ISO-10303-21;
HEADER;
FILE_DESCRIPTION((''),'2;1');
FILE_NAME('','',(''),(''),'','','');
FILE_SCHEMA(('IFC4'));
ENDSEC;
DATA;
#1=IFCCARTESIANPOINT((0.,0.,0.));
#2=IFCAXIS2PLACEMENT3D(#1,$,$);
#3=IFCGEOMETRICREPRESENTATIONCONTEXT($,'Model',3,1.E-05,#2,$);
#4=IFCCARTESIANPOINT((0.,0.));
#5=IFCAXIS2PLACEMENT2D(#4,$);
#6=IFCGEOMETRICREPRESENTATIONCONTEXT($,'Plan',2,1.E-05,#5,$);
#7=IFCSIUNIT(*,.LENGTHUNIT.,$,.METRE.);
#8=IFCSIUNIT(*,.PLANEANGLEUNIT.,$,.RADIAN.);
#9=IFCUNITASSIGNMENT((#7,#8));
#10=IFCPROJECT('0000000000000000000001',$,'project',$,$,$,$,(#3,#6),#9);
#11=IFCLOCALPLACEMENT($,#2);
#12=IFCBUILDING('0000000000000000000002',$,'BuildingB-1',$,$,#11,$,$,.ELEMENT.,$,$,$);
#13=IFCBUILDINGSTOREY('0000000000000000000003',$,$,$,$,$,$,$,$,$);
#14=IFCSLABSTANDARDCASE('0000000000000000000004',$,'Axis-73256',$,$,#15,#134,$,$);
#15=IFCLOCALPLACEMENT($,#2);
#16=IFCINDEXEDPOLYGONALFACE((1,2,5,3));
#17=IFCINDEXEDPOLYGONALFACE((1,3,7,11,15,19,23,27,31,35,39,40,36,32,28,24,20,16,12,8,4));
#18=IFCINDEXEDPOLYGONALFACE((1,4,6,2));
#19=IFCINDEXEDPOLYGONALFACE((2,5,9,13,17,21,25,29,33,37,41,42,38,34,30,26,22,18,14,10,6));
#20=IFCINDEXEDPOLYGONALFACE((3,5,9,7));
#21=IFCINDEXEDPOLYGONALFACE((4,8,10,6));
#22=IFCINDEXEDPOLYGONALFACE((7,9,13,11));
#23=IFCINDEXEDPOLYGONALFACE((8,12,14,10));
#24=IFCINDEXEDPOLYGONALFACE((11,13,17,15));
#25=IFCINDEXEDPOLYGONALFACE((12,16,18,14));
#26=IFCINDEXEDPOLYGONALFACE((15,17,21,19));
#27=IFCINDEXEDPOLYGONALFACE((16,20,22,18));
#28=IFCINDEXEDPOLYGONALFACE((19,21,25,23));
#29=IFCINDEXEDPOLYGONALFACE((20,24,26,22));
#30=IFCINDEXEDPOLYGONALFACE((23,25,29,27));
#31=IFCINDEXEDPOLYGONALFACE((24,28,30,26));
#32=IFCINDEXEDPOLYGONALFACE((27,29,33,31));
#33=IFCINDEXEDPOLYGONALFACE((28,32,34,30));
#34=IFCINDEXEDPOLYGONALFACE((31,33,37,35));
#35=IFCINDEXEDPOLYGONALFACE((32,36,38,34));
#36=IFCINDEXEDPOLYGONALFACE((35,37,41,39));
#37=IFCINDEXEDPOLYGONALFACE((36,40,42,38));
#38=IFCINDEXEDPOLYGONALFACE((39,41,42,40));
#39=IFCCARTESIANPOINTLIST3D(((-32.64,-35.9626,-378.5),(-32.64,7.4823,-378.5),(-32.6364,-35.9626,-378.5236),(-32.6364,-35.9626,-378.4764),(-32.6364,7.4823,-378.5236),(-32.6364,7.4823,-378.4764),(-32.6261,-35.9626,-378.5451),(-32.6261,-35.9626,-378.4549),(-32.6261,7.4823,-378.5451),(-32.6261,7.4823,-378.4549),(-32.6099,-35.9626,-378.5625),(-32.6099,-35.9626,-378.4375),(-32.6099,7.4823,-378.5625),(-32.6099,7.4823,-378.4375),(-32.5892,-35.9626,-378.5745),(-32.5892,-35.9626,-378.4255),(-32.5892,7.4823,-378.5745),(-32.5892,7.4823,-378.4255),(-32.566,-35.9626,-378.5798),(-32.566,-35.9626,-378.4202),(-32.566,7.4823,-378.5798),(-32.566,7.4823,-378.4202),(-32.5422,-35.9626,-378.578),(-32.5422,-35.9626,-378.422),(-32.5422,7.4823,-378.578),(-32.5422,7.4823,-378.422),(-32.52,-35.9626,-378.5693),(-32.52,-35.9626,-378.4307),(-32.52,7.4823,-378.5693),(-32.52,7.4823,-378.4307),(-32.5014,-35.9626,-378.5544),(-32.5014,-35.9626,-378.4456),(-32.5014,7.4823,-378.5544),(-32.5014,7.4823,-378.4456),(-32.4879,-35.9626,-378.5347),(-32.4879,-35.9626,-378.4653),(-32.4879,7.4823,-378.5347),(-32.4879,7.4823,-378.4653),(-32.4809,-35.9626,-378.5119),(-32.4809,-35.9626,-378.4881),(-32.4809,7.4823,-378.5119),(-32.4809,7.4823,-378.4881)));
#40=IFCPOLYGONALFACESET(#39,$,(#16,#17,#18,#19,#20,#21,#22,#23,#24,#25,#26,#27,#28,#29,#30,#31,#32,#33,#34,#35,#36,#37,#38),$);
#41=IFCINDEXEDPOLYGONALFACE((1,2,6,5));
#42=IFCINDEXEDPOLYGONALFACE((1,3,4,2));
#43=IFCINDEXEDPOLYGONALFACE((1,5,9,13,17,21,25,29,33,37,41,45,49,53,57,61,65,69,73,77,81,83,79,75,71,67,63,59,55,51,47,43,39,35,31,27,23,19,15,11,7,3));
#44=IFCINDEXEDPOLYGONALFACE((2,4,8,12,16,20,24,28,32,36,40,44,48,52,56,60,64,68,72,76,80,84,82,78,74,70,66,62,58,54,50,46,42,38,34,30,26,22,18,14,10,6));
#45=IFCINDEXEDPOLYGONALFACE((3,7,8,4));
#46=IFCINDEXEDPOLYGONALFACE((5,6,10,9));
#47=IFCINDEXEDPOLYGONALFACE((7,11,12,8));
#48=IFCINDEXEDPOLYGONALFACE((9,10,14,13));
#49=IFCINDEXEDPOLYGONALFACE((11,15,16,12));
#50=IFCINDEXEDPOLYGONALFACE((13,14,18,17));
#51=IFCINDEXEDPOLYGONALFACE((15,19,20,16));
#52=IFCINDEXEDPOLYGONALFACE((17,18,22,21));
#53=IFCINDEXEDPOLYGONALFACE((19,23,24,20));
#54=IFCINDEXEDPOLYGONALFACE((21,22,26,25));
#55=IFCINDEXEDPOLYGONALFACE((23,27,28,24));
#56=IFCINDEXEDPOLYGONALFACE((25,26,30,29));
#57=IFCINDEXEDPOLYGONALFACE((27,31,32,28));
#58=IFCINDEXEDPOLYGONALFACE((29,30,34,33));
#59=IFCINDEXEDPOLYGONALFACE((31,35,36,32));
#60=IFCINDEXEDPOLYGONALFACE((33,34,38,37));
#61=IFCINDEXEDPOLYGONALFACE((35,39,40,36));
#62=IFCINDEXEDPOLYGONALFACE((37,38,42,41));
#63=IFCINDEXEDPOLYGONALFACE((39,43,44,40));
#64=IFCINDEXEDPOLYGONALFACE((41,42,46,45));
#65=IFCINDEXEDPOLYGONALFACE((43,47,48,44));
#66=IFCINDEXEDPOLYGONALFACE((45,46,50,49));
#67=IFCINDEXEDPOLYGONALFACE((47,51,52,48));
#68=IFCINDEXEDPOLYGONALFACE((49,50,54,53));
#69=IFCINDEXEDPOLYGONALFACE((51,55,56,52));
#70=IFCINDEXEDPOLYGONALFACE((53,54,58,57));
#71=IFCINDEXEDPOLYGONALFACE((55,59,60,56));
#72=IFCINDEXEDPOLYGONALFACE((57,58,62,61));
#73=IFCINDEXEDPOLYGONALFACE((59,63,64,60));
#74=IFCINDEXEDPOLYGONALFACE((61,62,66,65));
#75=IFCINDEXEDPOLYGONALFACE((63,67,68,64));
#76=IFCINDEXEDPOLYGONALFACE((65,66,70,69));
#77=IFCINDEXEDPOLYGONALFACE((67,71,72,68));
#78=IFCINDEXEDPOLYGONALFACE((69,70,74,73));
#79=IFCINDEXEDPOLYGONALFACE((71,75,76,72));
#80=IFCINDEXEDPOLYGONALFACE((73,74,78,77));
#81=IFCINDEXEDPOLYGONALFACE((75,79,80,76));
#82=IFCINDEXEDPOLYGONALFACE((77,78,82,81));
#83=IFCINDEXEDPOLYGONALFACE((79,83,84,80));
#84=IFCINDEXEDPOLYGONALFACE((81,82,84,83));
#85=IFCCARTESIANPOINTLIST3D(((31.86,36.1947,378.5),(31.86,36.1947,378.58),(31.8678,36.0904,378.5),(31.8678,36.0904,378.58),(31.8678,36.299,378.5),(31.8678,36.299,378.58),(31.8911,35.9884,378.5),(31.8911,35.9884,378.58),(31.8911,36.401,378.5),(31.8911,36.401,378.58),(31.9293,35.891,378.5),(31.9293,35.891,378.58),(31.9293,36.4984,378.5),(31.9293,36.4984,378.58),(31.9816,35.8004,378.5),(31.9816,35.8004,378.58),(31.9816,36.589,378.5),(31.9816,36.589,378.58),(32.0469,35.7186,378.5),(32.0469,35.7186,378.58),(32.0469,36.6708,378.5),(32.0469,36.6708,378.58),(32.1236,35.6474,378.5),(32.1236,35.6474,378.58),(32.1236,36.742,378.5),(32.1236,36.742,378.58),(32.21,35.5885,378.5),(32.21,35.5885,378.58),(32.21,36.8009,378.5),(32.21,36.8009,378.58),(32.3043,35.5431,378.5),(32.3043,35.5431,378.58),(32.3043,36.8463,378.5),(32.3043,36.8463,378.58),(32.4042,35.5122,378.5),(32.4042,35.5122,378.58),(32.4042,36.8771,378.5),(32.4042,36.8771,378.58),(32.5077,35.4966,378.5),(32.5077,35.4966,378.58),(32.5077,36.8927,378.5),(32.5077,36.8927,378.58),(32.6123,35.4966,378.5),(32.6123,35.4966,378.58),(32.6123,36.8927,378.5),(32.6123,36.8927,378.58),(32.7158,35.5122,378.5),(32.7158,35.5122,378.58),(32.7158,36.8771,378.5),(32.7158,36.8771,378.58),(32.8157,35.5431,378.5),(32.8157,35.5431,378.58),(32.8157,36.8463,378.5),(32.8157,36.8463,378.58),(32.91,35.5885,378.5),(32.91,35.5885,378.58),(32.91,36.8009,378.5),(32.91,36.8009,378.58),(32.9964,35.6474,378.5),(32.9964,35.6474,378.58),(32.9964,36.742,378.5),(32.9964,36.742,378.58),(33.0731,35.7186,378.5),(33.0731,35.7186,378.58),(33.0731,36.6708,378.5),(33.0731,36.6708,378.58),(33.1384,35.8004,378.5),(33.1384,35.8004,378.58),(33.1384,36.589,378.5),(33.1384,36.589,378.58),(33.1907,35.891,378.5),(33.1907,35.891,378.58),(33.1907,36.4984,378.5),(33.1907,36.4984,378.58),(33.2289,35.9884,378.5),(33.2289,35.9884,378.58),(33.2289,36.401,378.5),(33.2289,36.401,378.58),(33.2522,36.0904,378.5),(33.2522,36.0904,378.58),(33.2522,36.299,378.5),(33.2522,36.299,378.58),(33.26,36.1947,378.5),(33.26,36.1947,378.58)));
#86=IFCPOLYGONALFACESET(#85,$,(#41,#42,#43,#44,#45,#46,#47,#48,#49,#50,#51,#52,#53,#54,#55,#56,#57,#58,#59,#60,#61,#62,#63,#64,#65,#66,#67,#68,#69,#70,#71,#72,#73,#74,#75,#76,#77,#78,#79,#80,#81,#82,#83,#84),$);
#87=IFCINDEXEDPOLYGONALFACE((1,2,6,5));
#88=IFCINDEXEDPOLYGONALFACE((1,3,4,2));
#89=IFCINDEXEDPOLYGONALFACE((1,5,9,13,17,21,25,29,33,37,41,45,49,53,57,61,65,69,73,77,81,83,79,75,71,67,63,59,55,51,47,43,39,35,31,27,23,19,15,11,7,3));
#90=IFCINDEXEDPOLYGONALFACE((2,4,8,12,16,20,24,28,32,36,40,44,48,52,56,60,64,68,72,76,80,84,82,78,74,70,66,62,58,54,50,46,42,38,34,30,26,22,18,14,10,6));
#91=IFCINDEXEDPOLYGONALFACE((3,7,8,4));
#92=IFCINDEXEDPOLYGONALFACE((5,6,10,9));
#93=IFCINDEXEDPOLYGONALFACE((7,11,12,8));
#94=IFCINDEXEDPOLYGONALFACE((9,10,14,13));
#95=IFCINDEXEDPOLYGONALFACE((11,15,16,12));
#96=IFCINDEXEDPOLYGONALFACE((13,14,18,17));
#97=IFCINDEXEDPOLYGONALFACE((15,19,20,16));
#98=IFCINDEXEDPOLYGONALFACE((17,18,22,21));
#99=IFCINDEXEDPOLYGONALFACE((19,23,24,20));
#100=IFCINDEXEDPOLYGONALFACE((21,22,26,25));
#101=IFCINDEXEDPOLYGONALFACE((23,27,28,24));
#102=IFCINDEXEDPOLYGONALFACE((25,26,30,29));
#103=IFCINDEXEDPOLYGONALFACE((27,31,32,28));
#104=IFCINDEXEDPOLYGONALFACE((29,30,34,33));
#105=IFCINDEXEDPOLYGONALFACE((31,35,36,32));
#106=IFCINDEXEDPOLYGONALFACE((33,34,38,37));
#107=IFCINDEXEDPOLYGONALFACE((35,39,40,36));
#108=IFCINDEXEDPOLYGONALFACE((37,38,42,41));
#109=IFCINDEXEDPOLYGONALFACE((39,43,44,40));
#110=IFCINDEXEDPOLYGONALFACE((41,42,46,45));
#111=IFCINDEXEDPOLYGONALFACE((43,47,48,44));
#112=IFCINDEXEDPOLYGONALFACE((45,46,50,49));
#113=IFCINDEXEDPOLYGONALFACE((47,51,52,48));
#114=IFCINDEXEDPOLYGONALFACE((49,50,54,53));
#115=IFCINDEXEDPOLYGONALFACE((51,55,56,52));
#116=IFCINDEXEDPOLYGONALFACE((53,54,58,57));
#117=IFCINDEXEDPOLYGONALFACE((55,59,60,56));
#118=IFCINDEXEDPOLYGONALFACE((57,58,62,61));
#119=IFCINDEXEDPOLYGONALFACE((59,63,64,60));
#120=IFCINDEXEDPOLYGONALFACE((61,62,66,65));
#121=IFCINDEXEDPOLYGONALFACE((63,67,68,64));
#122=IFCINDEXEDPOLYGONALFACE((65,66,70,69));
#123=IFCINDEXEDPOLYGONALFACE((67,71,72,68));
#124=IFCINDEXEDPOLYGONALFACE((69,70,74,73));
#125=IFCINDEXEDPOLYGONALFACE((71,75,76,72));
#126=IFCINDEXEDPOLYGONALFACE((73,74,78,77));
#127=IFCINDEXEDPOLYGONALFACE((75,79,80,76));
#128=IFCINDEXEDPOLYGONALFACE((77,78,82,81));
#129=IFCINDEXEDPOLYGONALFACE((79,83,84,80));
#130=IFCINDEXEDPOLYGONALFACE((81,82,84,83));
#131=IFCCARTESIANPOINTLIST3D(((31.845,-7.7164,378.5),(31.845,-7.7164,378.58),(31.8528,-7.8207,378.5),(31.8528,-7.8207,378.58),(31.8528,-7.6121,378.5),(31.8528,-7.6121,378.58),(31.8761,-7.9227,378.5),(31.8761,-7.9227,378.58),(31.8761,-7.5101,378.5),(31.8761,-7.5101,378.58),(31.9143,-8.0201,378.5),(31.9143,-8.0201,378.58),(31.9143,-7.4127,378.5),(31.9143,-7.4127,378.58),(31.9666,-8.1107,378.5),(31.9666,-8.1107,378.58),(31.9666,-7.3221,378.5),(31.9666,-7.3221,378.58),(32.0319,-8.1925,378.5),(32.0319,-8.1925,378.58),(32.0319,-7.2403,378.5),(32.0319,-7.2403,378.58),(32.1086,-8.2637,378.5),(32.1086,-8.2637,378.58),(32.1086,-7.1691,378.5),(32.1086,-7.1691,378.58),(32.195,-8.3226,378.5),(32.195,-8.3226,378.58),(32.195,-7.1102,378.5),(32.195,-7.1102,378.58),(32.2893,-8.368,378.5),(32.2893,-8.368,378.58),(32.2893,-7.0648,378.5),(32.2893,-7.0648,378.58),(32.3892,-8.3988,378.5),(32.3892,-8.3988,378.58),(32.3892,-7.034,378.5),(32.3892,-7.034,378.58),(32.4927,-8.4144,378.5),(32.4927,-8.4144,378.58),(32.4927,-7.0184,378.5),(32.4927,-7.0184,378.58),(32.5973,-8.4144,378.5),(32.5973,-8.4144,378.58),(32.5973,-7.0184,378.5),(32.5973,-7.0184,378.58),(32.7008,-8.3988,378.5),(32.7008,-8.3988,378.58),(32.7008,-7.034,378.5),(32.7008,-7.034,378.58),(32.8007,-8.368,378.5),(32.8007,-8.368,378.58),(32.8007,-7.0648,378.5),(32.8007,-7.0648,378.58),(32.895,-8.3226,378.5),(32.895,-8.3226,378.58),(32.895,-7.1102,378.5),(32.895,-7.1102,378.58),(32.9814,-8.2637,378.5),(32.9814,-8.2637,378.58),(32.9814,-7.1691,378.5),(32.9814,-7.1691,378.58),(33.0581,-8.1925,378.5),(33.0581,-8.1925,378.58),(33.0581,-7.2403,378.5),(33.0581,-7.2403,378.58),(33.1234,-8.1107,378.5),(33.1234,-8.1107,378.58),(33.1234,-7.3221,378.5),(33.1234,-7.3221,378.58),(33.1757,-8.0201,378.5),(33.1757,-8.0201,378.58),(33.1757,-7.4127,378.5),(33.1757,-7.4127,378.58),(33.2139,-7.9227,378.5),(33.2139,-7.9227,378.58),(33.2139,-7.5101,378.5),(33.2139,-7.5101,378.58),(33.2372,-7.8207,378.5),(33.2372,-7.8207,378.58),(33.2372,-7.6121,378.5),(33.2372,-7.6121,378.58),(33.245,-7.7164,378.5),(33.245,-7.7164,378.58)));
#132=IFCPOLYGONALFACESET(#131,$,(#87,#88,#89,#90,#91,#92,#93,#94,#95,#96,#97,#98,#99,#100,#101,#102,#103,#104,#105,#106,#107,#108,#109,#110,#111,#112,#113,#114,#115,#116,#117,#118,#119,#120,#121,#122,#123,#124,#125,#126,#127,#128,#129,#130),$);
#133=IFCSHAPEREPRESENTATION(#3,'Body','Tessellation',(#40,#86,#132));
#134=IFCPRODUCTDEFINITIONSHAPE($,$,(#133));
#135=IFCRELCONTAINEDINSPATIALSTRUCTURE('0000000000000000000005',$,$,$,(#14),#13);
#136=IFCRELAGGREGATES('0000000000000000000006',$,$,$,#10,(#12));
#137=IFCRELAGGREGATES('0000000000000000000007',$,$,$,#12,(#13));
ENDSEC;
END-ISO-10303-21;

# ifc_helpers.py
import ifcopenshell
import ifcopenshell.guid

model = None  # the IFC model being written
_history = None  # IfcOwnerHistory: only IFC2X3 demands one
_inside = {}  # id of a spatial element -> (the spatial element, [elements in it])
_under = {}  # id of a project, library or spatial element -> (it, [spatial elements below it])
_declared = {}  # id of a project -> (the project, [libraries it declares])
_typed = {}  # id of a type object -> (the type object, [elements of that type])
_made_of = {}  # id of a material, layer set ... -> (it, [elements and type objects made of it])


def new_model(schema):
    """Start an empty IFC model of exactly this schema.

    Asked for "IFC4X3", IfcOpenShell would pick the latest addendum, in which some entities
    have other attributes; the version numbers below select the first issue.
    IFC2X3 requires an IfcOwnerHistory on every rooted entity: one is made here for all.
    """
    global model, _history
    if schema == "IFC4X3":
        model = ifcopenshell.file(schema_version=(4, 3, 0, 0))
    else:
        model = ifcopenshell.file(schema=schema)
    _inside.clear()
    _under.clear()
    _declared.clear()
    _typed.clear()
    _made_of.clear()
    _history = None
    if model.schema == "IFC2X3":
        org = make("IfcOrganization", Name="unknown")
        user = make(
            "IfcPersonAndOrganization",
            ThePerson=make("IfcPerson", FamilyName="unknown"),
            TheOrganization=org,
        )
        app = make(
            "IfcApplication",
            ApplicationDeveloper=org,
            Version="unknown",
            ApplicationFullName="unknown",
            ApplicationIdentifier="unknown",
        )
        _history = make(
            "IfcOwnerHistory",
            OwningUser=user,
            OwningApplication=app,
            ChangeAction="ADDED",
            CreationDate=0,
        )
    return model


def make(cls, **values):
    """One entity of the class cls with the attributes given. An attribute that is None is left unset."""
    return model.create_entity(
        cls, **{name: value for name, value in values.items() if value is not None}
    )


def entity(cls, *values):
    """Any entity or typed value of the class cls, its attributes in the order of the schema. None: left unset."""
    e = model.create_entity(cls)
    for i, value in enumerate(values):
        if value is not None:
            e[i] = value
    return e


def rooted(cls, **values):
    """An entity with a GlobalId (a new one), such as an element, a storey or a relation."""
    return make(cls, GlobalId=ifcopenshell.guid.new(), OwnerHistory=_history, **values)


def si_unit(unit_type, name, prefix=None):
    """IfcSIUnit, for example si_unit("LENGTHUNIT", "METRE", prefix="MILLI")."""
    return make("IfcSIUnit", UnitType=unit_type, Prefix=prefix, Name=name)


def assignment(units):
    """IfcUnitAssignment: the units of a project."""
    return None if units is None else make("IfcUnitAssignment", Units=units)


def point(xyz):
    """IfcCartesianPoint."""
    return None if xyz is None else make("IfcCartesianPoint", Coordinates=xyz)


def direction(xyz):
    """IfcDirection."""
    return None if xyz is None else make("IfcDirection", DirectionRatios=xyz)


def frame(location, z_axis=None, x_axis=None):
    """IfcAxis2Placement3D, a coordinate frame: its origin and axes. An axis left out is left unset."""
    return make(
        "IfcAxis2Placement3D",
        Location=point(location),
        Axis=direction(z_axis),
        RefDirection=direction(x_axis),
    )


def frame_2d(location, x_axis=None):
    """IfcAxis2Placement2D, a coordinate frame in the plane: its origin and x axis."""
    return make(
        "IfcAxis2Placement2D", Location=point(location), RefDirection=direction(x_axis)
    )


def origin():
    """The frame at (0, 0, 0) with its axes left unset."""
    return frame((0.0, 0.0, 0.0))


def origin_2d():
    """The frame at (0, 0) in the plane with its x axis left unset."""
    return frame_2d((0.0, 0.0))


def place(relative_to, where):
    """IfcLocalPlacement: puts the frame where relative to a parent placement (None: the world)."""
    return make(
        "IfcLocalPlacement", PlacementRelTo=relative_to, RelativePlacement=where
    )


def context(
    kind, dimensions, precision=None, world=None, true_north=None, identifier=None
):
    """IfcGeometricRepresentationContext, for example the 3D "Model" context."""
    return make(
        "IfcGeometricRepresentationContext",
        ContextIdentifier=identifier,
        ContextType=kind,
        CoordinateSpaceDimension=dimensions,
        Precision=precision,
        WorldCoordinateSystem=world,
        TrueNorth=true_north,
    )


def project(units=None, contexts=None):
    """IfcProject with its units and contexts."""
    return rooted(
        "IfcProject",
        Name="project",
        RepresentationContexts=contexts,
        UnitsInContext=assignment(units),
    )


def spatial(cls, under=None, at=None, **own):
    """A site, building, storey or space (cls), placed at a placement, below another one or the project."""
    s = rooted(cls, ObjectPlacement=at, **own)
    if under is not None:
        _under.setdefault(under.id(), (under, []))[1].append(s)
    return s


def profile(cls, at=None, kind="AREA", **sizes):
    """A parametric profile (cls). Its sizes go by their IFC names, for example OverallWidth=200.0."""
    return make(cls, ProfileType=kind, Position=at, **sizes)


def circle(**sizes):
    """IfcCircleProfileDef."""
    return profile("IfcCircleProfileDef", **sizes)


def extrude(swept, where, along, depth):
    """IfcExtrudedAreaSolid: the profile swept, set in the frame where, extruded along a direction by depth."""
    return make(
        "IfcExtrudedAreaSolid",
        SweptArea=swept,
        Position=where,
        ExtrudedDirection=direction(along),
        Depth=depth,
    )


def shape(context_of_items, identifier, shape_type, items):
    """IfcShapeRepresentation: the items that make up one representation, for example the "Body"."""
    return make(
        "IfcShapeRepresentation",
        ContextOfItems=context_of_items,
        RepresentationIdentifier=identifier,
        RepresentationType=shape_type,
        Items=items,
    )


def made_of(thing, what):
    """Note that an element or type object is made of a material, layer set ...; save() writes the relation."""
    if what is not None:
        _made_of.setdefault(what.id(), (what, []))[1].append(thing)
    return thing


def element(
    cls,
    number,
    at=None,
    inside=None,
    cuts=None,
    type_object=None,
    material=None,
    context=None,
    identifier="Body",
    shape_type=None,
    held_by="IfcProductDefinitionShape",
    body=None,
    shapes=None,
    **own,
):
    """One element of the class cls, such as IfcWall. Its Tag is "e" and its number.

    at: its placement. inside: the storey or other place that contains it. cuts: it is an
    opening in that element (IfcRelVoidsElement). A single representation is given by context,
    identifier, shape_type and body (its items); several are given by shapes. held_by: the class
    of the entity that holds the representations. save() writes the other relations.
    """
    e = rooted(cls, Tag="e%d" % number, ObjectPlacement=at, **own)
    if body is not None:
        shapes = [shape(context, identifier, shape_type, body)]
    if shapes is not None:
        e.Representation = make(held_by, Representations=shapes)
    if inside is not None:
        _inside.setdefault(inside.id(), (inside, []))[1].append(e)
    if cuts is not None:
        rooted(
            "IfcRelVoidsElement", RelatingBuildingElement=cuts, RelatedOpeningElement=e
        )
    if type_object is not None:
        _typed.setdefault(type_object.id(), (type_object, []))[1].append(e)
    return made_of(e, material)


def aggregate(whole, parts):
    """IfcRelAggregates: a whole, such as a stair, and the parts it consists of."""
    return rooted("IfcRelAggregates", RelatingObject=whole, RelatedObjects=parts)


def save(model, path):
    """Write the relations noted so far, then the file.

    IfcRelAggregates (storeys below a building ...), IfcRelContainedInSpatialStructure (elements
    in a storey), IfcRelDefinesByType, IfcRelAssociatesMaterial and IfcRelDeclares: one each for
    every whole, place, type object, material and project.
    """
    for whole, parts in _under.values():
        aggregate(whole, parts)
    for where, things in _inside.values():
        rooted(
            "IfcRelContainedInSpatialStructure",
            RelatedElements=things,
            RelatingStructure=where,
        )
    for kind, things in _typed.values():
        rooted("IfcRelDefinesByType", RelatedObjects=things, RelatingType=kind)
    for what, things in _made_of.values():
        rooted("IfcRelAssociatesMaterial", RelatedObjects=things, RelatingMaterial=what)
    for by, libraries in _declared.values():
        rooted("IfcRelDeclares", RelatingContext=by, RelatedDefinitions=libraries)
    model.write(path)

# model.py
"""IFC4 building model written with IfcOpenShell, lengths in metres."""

from ifc_helpers import new_model, entity, si_unit, frame, origin, origin_2d, place, context, project, spatial, circle, extrude, element, save


model = new_model("IFC4")

# Units and contexts
model_context = context("Model", 3, precision=1e-05, world=origin())
plan_context = context("Plan", 2, precision=1e-05, world=origin_2d())
ifc_project = project(units=[si_unit("LENGTHUNIT", "METRE"), si_unit("PLANEANGLEUNIT", "RADIAN")], contexts=[model_context, plan_context])

# Building, storey
building_placement = place(None, origin())
building = spatial("IfcBuilding", under=ifc_project, at=building_placement, Name="BuildingB-1", CompositionType="ELEMENT")
storey = spatial("IfcBuildingStorey", under=building)

# Slab
element("IfcSlabStandardCase", 1, inside=storey, Name="Axis-73256", context=model_context, shape_type="AdvancedSweptSolid", body=[
    entity("IfcSurfaceCurveSweptAreaSolid", entity("IfcCircleProfileDef", "AREA", None, None, 0.08), None, entity("IfcPolyline", [entity("IfcCartesianPoint", [32.56, 35.9626, 378.5]), entity("IfcCartesianPoint", [32.56, -7.4823, 378.5])]), None, None, entity("IfcPlane", entity("IfcAxis2Placement3D", entity("IfcCartesianPoint", [32.56, 35.9626, 378.5]), entity("IfcDirection", [0.0, 0.0, 1.0]), entity("IfcDirection", [1.0, 0.0, 0.0])))),
    extrude(circle(Radius=0.7), frame((32.56, 36.1947, 378.5)), (0.0, 0.0, 1.0), 0.08),
    extrude(circle(Radius=0.7), frame((32.545, -7.7164, 378.5)), (0.0, 0.0, 1.0), 0.08),
])

save(model, "model.ifc")
